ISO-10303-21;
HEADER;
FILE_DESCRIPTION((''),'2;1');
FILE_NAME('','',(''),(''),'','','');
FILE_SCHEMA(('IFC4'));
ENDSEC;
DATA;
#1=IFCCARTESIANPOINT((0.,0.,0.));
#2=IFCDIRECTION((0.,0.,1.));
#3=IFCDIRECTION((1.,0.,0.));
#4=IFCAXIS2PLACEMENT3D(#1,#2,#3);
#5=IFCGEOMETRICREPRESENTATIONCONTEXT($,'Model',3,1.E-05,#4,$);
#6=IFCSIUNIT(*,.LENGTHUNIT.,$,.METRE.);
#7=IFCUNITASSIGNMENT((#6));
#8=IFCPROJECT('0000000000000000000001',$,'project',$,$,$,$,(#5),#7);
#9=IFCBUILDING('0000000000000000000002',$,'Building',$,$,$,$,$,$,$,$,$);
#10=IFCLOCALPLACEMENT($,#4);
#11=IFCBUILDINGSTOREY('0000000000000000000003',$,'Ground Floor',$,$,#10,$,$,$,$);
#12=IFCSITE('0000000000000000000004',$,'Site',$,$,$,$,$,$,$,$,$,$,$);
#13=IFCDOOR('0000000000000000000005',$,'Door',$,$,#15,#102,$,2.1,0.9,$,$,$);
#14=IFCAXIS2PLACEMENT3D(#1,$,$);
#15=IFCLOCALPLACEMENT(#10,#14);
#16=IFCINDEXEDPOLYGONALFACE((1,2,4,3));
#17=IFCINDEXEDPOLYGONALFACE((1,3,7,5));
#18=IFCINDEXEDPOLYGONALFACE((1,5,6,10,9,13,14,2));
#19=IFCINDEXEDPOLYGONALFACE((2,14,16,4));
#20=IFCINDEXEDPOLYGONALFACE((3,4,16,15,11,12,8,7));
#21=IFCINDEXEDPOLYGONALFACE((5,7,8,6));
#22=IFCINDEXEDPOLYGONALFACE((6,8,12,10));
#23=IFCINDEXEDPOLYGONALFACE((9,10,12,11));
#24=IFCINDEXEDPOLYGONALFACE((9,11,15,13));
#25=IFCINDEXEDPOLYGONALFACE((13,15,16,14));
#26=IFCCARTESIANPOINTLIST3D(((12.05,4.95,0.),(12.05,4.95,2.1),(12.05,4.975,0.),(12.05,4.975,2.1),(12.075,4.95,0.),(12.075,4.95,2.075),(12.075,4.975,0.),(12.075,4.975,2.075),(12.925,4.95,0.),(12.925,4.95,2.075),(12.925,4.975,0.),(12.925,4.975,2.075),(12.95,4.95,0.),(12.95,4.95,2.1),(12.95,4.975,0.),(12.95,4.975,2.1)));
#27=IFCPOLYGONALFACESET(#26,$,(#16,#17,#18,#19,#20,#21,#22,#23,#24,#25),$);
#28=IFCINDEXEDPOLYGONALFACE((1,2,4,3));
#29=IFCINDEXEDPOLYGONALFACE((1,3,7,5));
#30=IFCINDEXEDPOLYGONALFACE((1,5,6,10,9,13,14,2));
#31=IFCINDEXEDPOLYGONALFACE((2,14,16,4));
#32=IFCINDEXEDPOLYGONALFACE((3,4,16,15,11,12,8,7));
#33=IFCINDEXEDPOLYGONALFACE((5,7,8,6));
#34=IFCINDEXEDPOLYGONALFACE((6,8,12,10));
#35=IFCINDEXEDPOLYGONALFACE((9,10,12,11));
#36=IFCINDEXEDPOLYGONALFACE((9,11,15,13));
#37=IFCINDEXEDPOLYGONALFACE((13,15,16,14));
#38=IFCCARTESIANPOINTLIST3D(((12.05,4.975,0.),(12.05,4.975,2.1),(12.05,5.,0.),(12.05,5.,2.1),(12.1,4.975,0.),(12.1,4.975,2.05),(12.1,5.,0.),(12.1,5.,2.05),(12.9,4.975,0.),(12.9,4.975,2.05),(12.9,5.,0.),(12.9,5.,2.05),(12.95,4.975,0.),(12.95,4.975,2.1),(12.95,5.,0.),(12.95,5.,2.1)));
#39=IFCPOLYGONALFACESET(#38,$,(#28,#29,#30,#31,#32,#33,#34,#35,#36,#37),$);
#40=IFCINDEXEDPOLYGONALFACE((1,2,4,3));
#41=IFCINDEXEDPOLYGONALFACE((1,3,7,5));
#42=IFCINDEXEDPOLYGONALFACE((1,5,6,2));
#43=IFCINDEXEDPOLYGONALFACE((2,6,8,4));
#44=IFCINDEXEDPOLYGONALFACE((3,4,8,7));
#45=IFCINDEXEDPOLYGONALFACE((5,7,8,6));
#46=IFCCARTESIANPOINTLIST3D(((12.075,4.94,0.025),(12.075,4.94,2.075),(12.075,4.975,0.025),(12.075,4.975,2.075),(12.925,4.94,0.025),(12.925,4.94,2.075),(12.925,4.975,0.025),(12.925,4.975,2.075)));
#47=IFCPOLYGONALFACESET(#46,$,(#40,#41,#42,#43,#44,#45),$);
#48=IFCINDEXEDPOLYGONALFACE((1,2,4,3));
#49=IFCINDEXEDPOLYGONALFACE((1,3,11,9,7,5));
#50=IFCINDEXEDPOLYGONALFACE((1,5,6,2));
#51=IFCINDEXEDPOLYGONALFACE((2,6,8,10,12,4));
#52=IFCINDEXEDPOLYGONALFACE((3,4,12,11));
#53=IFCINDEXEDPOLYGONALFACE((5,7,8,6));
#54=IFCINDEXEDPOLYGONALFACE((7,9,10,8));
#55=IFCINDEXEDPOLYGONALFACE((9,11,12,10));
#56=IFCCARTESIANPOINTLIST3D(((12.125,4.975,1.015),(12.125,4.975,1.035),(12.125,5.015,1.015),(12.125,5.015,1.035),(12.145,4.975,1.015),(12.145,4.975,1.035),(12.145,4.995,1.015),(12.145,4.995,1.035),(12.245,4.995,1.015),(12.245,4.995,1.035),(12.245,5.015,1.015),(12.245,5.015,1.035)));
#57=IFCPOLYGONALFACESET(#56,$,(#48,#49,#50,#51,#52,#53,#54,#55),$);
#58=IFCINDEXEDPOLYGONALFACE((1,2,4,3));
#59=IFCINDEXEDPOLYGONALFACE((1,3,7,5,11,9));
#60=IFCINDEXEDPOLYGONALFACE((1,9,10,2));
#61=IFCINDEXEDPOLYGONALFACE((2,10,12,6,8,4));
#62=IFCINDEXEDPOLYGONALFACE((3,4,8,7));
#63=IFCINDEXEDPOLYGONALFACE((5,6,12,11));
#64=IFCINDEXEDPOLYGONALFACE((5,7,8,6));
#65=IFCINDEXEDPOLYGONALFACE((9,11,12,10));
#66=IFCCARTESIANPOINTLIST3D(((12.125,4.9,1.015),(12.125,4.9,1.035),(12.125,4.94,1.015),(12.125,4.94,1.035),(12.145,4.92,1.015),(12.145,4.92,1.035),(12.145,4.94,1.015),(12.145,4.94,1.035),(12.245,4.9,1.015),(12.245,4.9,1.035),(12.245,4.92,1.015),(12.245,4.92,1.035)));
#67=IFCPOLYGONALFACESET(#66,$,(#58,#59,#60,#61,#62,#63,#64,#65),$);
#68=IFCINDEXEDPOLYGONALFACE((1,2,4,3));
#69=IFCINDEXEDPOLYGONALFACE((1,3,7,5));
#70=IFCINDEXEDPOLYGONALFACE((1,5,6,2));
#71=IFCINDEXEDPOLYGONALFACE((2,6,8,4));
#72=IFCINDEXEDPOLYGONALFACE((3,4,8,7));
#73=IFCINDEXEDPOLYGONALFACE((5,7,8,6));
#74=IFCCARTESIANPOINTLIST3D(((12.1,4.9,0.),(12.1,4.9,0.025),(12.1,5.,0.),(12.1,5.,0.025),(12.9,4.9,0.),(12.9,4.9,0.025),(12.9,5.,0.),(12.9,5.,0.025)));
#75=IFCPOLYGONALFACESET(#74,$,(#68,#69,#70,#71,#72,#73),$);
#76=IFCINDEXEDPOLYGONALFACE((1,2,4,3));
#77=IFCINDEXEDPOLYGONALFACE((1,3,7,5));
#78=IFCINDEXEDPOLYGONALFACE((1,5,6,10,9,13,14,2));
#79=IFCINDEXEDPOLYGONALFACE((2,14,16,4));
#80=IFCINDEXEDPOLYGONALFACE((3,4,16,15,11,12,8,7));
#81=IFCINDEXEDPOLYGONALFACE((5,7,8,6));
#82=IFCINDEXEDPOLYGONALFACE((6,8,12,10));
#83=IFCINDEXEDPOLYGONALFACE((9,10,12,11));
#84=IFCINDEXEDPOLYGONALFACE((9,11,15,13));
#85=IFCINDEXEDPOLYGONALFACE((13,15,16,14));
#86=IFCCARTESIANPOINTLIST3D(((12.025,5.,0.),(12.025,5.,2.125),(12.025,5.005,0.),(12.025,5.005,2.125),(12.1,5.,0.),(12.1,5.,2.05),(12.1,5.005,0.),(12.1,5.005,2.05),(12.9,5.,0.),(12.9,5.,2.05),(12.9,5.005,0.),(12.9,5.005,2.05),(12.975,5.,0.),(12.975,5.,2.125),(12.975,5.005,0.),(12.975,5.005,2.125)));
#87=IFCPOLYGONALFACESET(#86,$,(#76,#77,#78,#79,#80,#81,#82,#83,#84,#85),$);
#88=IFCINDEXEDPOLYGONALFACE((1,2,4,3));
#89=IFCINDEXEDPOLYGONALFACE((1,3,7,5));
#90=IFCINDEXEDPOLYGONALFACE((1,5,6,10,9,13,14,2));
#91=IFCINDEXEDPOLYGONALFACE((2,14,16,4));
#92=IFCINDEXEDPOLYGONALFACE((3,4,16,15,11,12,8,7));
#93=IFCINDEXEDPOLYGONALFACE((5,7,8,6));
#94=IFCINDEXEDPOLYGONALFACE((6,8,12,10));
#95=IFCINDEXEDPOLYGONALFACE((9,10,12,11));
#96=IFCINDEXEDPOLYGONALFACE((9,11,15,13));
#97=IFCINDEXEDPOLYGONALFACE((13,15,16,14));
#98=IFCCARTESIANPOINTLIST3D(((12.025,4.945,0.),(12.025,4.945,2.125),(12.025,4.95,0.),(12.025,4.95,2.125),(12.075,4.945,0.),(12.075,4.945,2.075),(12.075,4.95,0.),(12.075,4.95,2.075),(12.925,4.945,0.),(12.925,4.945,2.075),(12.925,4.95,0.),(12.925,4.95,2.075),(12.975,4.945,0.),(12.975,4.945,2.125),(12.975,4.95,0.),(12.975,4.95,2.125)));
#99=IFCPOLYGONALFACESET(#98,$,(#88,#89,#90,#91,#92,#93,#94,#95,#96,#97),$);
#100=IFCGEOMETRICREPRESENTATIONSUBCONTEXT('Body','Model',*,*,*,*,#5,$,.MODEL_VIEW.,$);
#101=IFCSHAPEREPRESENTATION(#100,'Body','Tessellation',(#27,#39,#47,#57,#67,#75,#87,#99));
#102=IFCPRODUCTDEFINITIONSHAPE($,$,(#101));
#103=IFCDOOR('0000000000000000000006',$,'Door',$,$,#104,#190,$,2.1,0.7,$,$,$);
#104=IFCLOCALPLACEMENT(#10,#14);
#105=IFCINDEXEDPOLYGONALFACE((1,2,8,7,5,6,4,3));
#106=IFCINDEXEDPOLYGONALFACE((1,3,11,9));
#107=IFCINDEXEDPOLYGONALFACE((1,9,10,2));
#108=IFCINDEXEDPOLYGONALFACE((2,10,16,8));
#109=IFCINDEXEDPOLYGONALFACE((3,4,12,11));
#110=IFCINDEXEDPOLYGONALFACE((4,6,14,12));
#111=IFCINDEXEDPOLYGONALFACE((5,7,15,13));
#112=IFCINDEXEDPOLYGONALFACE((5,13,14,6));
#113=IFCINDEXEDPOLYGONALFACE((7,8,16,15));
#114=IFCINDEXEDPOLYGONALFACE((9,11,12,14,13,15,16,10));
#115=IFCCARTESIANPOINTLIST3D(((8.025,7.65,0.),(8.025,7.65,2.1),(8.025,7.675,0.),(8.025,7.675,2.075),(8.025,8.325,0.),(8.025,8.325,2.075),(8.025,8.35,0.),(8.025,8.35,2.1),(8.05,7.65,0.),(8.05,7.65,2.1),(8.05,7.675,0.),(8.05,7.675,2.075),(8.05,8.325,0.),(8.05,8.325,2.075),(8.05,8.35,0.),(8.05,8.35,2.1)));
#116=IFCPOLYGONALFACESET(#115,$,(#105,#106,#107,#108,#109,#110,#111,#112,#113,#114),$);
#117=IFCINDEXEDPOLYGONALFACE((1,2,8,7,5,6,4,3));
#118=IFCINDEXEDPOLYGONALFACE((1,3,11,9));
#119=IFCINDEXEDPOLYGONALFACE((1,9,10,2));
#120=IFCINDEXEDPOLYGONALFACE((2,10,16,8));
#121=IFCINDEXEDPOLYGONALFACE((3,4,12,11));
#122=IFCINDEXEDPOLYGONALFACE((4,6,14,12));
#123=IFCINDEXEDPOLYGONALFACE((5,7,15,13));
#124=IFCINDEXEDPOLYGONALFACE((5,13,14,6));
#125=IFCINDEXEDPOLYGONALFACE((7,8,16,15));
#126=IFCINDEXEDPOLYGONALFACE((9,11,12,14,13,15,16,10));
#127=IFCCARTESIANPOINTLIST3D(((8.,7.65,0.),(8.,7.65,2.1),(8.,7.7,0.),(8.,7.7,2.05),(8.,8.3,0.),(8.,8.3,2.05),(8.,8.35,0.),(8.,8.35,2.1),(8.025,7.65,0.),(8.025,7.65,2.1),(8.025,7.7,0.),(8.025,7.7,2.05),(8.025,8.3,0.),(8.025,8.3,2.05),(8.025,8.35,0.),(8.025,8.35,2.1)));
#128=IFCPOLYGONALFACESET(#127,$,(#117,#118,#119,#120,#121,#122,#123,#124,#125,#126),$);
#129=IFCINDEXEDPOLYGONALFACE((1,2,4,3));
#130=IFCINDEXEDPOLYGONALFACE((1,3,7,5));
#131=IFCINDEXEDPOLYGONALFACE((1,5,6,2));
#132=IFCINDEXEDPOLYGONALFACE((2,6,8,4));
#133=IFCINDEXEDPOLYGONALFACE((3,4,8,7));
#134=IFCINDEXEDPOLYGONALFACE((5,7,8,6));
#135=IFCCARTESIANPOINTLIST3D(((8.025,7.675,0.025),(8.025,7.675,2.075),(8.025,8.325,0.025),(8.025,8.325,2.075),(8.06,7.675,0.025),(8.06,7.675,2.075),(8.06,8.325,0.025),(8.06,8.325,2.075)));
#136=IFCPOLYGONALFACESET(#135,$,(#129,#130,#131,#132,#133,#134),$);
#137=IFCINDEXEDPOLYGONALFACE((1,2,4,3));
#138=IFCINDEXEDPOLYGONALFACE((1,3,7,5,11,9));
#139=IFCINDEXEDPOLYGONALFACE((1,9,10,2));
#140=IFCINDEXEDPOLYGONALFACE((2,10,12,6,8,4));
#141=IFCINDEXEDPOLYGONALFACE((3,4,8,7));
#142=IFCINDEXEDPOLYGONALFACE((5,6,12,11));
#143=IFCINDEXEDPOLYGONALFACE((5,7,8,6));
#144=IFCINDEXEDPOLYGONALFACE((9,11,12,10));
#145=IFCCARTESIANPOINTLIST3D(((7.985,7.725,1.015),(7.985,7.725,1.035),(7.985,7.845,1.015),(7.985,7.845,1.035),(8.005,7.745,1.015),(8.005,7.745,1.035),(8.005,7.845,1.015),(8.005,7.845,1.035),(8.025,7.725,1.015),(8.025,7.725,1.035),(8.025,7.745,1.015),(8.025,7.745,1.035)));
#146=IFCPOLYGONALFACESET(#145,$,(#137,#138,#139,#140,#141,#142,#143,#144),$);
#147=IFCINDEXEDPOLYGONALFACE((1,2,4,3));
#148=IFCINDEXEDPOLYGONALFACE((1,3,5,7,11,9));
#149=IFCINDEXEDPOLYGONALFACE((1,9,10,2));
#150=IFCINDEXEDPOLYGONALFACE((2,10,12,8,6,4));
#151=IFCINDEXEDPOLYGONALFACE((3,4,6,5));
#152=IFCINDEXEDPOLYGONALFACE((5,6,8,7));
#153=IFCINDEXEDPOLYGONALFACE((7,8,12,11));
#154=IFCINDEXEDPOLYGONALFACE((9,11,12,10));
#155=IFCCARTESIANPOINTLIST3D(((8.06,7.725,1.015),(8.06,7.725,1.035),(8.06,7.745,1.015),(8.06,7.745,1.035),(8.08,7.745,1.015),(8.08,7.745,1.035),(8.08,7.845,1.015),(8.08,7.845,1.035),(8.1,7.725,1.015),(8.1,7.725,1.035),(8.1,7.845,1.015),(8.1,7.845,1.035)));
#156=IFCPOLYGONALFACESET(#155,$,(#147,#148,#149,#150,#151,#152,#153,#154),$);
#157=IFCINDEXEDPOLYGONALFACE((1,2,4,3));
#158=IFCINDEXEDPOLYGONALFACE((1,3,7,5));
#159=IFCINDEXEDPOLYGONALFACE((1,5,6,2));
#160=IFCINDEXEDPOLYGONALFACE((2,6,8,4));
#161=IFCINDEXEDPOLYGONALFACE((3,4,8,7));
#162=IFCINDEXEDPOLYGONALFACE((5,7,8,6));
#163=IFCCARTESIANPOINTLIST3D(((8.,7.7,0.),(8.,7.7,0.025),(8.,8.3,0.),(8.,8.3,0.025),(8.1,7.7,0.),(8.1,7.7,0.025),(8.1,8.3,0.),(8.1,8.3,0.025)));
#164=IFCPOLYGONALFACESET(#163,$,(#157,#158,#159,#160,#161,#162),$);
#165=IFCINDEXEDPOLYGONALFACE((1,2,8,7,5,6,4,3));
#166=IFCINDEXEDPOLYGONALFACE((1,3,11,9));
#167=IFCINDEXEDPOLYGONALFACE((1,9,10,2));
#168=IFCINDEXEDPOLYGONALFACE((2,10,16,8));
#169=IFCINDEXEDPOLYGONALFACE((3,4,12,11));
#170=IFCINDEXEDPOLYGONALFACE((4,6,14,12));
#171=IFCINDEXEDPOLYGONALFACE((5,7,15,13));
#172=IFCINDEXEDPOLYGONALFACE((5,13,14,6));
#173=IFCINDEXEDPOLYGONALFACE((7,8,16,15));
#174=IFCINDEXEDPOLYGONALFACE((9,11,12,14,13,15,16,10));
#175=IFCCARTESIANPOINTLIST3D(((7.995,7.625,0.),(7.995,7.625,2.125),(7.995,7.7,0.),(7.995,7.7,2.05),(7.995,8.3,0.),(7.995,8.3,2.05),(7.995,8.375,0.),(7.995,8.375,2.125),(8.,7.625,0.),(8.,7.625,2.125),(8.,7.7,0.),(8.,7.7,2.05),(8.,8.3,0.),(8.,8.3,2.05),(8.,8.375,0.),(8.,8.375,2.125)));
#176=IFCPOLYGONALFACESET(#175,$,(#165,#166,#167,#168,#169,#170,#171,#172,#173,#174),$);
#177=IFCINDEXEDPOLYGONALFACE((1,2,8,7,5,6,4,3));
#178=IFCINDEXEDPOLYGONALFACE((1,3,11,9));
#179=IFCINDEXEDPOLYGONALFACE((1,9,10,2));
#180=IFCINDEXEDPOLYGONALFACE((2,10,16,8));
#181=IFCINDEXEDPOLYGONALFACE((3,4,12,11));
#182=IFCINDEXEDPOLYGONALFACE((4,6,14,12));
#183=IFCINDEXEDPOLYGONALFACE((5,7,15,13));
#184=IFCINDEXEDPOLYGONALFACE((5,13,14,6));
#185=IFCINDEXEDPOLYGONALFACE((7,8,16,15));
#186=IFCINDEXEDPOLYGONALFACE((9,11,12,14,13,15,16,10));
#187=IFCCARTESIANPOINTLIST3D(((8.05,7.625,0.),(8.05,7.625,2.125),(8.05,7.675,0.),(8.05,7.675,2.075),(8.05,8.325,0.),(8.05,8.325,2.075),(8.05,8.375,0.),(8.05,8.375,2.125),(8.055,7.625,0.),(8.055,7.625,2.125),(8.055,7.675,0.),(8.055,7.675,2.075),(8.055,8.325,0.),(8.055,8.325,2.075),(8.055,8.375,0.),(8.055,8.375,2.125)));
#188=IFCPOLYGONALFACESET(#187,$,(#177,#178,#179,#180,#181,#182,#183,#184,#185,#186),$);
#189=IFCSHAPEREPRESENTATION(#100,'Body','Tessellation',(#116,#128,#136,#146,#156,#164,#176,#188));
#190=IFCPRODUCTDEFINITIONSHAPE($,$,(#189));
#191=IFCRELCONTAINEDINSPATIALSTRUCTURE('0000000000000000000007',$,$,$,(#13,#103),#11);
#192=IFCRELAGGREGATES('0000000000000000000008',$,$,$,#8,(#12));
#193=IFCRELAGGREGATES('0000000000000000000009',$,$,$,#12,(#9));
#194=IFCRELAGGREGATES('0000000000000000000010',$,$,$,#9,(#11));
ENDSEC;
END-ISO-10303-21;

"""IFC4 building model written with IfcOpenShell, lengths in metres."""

from ifc_helpers import new_model, si_unit, frame, origin_with_axes, place, context, subcontext, project, spatial, line, indexed_curve, outline, extrude, element, save


model = new_model("IFC4")

# Units and contexts
model_context = context("Model", 3, precision=1e-05, world=origin_with_axes())
body_context = subcontext(model_context, "Body", "Model", "MODEL_VIEW")
ifc_project = project(units=[si_unit("LENGTHUNIT", "METRE")], contexts=[model_context])

# Site, building, storey
site = spatial("IfcSite", under=ifc_project, Name="Site")
building = spatial("IfcBuilding", under=site, Name="Building")
storey_placement = place(None, origin_with_axes())
storey = spatial("IfcBuildingStorey", under=building, at=storey_placement, Name="Ground Floor")

# Doors
door_1_placement = place(storey_placement, frame((12.95, 5.0, 0.0), z_axis=(0.0, 0.0, 1.0), x_axis=(-1.0, 0.0, 0.0)))
element("IfcDoor", 1, at=door_1_placement, inside=storey, Name="Door", OverallHeight=2.1, OverallWidth=0.9, context=body_context, shape_type="SweptSolid", body=[
    extrude(outline(indexed_curve([(0.0, 0.0), (0.0, 2.1), (0.9, 2.1), (0.9, 0.0), (0.875, 0.0), (0.875, 2.075), (0.025, 2.075), (0.025, 0.0)], segments=[line(1, 2, 3, 4, 5, 6, 7, 8, 1)])), frame((0.0, 0.025, 0.0), z_axis=(0.0, -1.0, 0.0), x_axis=(1.0, 0.0, 0.0)), (0.0, 0.0, -1.0), 0.025),
    extrude(outline(indexed_curve([(0.0, 0.0), (0.0, 2.1), (0.9, 2.1), (0.9, 0.0), (0.85, 0.0), (0.85, 2.05), (0.05, 2.05), (0.05, 0.0)], segments=[line(1, 2, 3, 4, 5, 6, 7, 8, 1)])), frame((0.0, 0.0, 0.0), z_axis=(0.0, -1.0, 0.0), x_axis=(1.0, 0.0, 0.0)), (0.0, 0.0, -1.0), 0.025),
    extrude(outline(indexed_curve([(0.0, 0.0), (0.85, 0.0), (0.85, 0.035), (0.0, 0.035)], segments=[line(1, 2, 3, 4, 1)])), frame((0.025, 0.025, 0.025), z_axis=(0.0, 0.0, 1.0), x_axis=(1.0, 0.0, 0.0)), (0.0, 0.0, 1.0), 2.05),
    extrude(outline(indexed_curve([(0.0, 0.0), (0.0, -0.04), (-0.12, -0.04), (-0.12, -0.02), (-0.02, -0.02), (-0.02, 0.0)], segments=[line(1, 2, 3, 4, 5, 6, 1)])), frame((0.825, 0.025, 1.015), z_axis=(0.0, 0.0, 1.0), x_axis=(1.0, 0.0, 0.0)), (0.0, 0.0, 1.0), 0.02),
    extrude(outline(indexed_curve([(0.0, 0.0), (0.0, 0.04), (-0.12, 0.04), (-0.12, 0.02), (-0.02, 0.02), (-0.02, 0.0)], segments=[line(1, 2, 3, 4, 5, 6, 1)])), frame((0.825, 0.06, 1.015), z_axis=(0.0, 0.0, 1.0), x_axis=(1.0, 0.0, 0.0)), (0.0, 0.0, 1.0), 0.02),
    extrude(outline(indexed_curve([(0.0, 0.0), (0.8, 0.0), (0.8, 0.1), (0.0, 0.1)], segments=[line(1, 2, 3, 4, 1)])), frame((0.05, 0.0, 0.0), z_axis=(0.0, 0.0, 1.0), x_axis=(1.0, 0.0, 0.0)), (0.0, 0.0, 1.0), 0.025),
    extrude(outline(indexed_curve([(0.0, 0.0), (0.0, 2.125), (0.95, 2.125), (0.95, 0.0), (0.875, 0.0), (0.875, 2.05), (0.075, 2.05), (0.075, 0.0)], segments=[line(1, 2, 3, 4, 5, 6, 7, 8, 1)])), frame((-0.025, -0.005, 0.0), z_axis=(0.0, -1.0, 0.0), x_axis=(1.0, 0.0, 0.0)), (0.0, 0.0, -1.0), 0.005),
    extrude(outline(indexed_curve([(0.0, 0.0), (0.0, 2.125), (0.95, 2.125), (0.95, 0.0), (0.9, 0.0), (0.9, 2.075), (0.05, 2.075), (0.05, 0.0)], segments=[line(1, 2, 3, 4, 5, 6, 7, 8, 1)])), frame((-0.025, 0.05, 0.0), z_axis=(0.0, -1.0, 0.0), x_axis=(1.0, 0.0, 0.0)), (0.0, 0.0, -1.0), 0.005),
])
door_2_placement = place(storey_placement, frame((8.0, 8.35, 0.0), z_axis=(0.0, 0.0, 1.0), x_axis=(0.0, -1.0, 0.0)))
element("IfcDoor", 2, at=door_2_placement, inside=storey, Name="Door", OverallHeight=2.1, OverallWidth=0.7, context=body_context, shape_type="SweptSolid", body=[
    extrude(outline(indexed_curve([(0.0, 0.0), (0.0, 2.1), (0.7, 2.1), (0.7, 0.0), (0.675, 0.0), (0.675, 2.075), (0.025, 2.075), (0.025, 0.0)], segments=[line(1, 2, 3, 4, 5, 6, 7, 8, 1)])), frame((0.0, 0.025, 0.0), z_axis=(0.0, -1.0, 0.0), x_axis=(1.0, 0.0, 0.0)), (0.0, 0.0, -1.0), 0.025),
    extrude(outline(indexed_curve([(0.0, 0.0), (0.0, 2.1), (0.7, 2.1), (0.7, 0.0), (0.65, 0.0), (0.65, 2.05), (0.05, 2.05), (0.05, 0.0)], segments=[line(1, 2, 3, 4, 5, 6, 7, 8, 1)])), frame((0.0, 0.0, 0.0), z_axis=(0.0, -1.0, 0.0), x_axis=(1.0, 0.0, 0.0)), (0.0, 0.0, -1.0), 0.025),
    extrude(outline(indexed_curve([(0.0, 0.0), (0.65, 0.0), (0.65, 0.035), (0.0, 0.035)], segments=[line(1, 2, 3, 4, 1)])), frame((0.025, 0.025, 0.025), z_axis=(0.0, 0.0, 1.0), x_axis=(1.0, 0.0, 0.0)), (0.0, 0.0, 1.0), 2.05),
    extrude(outline(indexed_curve([(0.0, 0.0), (0.0, -0.04), (-0.12, -0.04), (-0.12, -0.02), (-0.02, -0.02), (-0.02, 0.0)], segments=[line(1, 2, 3, 4, 5, 6, 1)])), frame((0.625, 0.025, 1.015), z_axis=(0.0, 0.0, 1.0), x_axis=(1.0, 0.0, 0.0)), (0.0, 0.0, 1.0), 0.02),
    extrude(outline(indexed_curve([(0.0, 0.0), (0.0, 0.04), (-0.12, 0.04), (-0.12, 0.02), (-0.02, 0.02), (-0.02, 0.0)], segments=[line(1, 2, 3, 4, 5, 6, 1)])), frame((0.625, 0.06, 1.015), z_axis=(0.0, 0.0, 1.0), x_axis=(1.0, 0.0, 0.0)), (0.0, 0.0, 1.0), 0.02),
    extrude(outline(indexed_curve([(0.0, 0.0), (0.6, 0.0), (0.6, 0.1), (0.0, 0.1)], segments=[line(1, 2, 3, 4, 1)])), frame((0.05, 0.0, 0.0), z_axis=(0.0, 0.0, 1.0), x_axis=(1.0, 0.0, 0.0)), (0.0, 0.0, 1.0), 0.025),
    extrude(outline(indexed_curve([(0.0, 0.0), (0.0, 2.125), (0.75, 2.125), (0.75, 0.0), (0.675, 0.0), (0.675, 2.05), (0.075, 2.05), (0.075, 0.0)], segments=[line(1, 2, 3, 4, 5, 6, 7, 8, 1)])), frame((-0.025, -0.005, 0.0), z_axis=(0.0, -1.0, 0.0), x_axis=(1.0, 0.0, 0.0)), (0.0, 0.0, -1.0), 0.005),
    extrude(outline(indexed_curve([(0.0, 0.0), (0.0, 2.125), (0.75, 2.125), (0.75, 0.0), (0.7, 0.0), (0.7, 2.075), (0.05, 2.075), (0.05, 0.0)], segments=[line(1, 2, 3, 4, 5, 6, 7, 8, 1)])), frame((-0.025, 0.05, 0.0), z_axis=(0.0, -1.0, 0.0), x_axis=(1.0, 0.0, 0.0)), (0.0, 0.0, -1.0), 0.005),
])

save(model, "model.ifc")
